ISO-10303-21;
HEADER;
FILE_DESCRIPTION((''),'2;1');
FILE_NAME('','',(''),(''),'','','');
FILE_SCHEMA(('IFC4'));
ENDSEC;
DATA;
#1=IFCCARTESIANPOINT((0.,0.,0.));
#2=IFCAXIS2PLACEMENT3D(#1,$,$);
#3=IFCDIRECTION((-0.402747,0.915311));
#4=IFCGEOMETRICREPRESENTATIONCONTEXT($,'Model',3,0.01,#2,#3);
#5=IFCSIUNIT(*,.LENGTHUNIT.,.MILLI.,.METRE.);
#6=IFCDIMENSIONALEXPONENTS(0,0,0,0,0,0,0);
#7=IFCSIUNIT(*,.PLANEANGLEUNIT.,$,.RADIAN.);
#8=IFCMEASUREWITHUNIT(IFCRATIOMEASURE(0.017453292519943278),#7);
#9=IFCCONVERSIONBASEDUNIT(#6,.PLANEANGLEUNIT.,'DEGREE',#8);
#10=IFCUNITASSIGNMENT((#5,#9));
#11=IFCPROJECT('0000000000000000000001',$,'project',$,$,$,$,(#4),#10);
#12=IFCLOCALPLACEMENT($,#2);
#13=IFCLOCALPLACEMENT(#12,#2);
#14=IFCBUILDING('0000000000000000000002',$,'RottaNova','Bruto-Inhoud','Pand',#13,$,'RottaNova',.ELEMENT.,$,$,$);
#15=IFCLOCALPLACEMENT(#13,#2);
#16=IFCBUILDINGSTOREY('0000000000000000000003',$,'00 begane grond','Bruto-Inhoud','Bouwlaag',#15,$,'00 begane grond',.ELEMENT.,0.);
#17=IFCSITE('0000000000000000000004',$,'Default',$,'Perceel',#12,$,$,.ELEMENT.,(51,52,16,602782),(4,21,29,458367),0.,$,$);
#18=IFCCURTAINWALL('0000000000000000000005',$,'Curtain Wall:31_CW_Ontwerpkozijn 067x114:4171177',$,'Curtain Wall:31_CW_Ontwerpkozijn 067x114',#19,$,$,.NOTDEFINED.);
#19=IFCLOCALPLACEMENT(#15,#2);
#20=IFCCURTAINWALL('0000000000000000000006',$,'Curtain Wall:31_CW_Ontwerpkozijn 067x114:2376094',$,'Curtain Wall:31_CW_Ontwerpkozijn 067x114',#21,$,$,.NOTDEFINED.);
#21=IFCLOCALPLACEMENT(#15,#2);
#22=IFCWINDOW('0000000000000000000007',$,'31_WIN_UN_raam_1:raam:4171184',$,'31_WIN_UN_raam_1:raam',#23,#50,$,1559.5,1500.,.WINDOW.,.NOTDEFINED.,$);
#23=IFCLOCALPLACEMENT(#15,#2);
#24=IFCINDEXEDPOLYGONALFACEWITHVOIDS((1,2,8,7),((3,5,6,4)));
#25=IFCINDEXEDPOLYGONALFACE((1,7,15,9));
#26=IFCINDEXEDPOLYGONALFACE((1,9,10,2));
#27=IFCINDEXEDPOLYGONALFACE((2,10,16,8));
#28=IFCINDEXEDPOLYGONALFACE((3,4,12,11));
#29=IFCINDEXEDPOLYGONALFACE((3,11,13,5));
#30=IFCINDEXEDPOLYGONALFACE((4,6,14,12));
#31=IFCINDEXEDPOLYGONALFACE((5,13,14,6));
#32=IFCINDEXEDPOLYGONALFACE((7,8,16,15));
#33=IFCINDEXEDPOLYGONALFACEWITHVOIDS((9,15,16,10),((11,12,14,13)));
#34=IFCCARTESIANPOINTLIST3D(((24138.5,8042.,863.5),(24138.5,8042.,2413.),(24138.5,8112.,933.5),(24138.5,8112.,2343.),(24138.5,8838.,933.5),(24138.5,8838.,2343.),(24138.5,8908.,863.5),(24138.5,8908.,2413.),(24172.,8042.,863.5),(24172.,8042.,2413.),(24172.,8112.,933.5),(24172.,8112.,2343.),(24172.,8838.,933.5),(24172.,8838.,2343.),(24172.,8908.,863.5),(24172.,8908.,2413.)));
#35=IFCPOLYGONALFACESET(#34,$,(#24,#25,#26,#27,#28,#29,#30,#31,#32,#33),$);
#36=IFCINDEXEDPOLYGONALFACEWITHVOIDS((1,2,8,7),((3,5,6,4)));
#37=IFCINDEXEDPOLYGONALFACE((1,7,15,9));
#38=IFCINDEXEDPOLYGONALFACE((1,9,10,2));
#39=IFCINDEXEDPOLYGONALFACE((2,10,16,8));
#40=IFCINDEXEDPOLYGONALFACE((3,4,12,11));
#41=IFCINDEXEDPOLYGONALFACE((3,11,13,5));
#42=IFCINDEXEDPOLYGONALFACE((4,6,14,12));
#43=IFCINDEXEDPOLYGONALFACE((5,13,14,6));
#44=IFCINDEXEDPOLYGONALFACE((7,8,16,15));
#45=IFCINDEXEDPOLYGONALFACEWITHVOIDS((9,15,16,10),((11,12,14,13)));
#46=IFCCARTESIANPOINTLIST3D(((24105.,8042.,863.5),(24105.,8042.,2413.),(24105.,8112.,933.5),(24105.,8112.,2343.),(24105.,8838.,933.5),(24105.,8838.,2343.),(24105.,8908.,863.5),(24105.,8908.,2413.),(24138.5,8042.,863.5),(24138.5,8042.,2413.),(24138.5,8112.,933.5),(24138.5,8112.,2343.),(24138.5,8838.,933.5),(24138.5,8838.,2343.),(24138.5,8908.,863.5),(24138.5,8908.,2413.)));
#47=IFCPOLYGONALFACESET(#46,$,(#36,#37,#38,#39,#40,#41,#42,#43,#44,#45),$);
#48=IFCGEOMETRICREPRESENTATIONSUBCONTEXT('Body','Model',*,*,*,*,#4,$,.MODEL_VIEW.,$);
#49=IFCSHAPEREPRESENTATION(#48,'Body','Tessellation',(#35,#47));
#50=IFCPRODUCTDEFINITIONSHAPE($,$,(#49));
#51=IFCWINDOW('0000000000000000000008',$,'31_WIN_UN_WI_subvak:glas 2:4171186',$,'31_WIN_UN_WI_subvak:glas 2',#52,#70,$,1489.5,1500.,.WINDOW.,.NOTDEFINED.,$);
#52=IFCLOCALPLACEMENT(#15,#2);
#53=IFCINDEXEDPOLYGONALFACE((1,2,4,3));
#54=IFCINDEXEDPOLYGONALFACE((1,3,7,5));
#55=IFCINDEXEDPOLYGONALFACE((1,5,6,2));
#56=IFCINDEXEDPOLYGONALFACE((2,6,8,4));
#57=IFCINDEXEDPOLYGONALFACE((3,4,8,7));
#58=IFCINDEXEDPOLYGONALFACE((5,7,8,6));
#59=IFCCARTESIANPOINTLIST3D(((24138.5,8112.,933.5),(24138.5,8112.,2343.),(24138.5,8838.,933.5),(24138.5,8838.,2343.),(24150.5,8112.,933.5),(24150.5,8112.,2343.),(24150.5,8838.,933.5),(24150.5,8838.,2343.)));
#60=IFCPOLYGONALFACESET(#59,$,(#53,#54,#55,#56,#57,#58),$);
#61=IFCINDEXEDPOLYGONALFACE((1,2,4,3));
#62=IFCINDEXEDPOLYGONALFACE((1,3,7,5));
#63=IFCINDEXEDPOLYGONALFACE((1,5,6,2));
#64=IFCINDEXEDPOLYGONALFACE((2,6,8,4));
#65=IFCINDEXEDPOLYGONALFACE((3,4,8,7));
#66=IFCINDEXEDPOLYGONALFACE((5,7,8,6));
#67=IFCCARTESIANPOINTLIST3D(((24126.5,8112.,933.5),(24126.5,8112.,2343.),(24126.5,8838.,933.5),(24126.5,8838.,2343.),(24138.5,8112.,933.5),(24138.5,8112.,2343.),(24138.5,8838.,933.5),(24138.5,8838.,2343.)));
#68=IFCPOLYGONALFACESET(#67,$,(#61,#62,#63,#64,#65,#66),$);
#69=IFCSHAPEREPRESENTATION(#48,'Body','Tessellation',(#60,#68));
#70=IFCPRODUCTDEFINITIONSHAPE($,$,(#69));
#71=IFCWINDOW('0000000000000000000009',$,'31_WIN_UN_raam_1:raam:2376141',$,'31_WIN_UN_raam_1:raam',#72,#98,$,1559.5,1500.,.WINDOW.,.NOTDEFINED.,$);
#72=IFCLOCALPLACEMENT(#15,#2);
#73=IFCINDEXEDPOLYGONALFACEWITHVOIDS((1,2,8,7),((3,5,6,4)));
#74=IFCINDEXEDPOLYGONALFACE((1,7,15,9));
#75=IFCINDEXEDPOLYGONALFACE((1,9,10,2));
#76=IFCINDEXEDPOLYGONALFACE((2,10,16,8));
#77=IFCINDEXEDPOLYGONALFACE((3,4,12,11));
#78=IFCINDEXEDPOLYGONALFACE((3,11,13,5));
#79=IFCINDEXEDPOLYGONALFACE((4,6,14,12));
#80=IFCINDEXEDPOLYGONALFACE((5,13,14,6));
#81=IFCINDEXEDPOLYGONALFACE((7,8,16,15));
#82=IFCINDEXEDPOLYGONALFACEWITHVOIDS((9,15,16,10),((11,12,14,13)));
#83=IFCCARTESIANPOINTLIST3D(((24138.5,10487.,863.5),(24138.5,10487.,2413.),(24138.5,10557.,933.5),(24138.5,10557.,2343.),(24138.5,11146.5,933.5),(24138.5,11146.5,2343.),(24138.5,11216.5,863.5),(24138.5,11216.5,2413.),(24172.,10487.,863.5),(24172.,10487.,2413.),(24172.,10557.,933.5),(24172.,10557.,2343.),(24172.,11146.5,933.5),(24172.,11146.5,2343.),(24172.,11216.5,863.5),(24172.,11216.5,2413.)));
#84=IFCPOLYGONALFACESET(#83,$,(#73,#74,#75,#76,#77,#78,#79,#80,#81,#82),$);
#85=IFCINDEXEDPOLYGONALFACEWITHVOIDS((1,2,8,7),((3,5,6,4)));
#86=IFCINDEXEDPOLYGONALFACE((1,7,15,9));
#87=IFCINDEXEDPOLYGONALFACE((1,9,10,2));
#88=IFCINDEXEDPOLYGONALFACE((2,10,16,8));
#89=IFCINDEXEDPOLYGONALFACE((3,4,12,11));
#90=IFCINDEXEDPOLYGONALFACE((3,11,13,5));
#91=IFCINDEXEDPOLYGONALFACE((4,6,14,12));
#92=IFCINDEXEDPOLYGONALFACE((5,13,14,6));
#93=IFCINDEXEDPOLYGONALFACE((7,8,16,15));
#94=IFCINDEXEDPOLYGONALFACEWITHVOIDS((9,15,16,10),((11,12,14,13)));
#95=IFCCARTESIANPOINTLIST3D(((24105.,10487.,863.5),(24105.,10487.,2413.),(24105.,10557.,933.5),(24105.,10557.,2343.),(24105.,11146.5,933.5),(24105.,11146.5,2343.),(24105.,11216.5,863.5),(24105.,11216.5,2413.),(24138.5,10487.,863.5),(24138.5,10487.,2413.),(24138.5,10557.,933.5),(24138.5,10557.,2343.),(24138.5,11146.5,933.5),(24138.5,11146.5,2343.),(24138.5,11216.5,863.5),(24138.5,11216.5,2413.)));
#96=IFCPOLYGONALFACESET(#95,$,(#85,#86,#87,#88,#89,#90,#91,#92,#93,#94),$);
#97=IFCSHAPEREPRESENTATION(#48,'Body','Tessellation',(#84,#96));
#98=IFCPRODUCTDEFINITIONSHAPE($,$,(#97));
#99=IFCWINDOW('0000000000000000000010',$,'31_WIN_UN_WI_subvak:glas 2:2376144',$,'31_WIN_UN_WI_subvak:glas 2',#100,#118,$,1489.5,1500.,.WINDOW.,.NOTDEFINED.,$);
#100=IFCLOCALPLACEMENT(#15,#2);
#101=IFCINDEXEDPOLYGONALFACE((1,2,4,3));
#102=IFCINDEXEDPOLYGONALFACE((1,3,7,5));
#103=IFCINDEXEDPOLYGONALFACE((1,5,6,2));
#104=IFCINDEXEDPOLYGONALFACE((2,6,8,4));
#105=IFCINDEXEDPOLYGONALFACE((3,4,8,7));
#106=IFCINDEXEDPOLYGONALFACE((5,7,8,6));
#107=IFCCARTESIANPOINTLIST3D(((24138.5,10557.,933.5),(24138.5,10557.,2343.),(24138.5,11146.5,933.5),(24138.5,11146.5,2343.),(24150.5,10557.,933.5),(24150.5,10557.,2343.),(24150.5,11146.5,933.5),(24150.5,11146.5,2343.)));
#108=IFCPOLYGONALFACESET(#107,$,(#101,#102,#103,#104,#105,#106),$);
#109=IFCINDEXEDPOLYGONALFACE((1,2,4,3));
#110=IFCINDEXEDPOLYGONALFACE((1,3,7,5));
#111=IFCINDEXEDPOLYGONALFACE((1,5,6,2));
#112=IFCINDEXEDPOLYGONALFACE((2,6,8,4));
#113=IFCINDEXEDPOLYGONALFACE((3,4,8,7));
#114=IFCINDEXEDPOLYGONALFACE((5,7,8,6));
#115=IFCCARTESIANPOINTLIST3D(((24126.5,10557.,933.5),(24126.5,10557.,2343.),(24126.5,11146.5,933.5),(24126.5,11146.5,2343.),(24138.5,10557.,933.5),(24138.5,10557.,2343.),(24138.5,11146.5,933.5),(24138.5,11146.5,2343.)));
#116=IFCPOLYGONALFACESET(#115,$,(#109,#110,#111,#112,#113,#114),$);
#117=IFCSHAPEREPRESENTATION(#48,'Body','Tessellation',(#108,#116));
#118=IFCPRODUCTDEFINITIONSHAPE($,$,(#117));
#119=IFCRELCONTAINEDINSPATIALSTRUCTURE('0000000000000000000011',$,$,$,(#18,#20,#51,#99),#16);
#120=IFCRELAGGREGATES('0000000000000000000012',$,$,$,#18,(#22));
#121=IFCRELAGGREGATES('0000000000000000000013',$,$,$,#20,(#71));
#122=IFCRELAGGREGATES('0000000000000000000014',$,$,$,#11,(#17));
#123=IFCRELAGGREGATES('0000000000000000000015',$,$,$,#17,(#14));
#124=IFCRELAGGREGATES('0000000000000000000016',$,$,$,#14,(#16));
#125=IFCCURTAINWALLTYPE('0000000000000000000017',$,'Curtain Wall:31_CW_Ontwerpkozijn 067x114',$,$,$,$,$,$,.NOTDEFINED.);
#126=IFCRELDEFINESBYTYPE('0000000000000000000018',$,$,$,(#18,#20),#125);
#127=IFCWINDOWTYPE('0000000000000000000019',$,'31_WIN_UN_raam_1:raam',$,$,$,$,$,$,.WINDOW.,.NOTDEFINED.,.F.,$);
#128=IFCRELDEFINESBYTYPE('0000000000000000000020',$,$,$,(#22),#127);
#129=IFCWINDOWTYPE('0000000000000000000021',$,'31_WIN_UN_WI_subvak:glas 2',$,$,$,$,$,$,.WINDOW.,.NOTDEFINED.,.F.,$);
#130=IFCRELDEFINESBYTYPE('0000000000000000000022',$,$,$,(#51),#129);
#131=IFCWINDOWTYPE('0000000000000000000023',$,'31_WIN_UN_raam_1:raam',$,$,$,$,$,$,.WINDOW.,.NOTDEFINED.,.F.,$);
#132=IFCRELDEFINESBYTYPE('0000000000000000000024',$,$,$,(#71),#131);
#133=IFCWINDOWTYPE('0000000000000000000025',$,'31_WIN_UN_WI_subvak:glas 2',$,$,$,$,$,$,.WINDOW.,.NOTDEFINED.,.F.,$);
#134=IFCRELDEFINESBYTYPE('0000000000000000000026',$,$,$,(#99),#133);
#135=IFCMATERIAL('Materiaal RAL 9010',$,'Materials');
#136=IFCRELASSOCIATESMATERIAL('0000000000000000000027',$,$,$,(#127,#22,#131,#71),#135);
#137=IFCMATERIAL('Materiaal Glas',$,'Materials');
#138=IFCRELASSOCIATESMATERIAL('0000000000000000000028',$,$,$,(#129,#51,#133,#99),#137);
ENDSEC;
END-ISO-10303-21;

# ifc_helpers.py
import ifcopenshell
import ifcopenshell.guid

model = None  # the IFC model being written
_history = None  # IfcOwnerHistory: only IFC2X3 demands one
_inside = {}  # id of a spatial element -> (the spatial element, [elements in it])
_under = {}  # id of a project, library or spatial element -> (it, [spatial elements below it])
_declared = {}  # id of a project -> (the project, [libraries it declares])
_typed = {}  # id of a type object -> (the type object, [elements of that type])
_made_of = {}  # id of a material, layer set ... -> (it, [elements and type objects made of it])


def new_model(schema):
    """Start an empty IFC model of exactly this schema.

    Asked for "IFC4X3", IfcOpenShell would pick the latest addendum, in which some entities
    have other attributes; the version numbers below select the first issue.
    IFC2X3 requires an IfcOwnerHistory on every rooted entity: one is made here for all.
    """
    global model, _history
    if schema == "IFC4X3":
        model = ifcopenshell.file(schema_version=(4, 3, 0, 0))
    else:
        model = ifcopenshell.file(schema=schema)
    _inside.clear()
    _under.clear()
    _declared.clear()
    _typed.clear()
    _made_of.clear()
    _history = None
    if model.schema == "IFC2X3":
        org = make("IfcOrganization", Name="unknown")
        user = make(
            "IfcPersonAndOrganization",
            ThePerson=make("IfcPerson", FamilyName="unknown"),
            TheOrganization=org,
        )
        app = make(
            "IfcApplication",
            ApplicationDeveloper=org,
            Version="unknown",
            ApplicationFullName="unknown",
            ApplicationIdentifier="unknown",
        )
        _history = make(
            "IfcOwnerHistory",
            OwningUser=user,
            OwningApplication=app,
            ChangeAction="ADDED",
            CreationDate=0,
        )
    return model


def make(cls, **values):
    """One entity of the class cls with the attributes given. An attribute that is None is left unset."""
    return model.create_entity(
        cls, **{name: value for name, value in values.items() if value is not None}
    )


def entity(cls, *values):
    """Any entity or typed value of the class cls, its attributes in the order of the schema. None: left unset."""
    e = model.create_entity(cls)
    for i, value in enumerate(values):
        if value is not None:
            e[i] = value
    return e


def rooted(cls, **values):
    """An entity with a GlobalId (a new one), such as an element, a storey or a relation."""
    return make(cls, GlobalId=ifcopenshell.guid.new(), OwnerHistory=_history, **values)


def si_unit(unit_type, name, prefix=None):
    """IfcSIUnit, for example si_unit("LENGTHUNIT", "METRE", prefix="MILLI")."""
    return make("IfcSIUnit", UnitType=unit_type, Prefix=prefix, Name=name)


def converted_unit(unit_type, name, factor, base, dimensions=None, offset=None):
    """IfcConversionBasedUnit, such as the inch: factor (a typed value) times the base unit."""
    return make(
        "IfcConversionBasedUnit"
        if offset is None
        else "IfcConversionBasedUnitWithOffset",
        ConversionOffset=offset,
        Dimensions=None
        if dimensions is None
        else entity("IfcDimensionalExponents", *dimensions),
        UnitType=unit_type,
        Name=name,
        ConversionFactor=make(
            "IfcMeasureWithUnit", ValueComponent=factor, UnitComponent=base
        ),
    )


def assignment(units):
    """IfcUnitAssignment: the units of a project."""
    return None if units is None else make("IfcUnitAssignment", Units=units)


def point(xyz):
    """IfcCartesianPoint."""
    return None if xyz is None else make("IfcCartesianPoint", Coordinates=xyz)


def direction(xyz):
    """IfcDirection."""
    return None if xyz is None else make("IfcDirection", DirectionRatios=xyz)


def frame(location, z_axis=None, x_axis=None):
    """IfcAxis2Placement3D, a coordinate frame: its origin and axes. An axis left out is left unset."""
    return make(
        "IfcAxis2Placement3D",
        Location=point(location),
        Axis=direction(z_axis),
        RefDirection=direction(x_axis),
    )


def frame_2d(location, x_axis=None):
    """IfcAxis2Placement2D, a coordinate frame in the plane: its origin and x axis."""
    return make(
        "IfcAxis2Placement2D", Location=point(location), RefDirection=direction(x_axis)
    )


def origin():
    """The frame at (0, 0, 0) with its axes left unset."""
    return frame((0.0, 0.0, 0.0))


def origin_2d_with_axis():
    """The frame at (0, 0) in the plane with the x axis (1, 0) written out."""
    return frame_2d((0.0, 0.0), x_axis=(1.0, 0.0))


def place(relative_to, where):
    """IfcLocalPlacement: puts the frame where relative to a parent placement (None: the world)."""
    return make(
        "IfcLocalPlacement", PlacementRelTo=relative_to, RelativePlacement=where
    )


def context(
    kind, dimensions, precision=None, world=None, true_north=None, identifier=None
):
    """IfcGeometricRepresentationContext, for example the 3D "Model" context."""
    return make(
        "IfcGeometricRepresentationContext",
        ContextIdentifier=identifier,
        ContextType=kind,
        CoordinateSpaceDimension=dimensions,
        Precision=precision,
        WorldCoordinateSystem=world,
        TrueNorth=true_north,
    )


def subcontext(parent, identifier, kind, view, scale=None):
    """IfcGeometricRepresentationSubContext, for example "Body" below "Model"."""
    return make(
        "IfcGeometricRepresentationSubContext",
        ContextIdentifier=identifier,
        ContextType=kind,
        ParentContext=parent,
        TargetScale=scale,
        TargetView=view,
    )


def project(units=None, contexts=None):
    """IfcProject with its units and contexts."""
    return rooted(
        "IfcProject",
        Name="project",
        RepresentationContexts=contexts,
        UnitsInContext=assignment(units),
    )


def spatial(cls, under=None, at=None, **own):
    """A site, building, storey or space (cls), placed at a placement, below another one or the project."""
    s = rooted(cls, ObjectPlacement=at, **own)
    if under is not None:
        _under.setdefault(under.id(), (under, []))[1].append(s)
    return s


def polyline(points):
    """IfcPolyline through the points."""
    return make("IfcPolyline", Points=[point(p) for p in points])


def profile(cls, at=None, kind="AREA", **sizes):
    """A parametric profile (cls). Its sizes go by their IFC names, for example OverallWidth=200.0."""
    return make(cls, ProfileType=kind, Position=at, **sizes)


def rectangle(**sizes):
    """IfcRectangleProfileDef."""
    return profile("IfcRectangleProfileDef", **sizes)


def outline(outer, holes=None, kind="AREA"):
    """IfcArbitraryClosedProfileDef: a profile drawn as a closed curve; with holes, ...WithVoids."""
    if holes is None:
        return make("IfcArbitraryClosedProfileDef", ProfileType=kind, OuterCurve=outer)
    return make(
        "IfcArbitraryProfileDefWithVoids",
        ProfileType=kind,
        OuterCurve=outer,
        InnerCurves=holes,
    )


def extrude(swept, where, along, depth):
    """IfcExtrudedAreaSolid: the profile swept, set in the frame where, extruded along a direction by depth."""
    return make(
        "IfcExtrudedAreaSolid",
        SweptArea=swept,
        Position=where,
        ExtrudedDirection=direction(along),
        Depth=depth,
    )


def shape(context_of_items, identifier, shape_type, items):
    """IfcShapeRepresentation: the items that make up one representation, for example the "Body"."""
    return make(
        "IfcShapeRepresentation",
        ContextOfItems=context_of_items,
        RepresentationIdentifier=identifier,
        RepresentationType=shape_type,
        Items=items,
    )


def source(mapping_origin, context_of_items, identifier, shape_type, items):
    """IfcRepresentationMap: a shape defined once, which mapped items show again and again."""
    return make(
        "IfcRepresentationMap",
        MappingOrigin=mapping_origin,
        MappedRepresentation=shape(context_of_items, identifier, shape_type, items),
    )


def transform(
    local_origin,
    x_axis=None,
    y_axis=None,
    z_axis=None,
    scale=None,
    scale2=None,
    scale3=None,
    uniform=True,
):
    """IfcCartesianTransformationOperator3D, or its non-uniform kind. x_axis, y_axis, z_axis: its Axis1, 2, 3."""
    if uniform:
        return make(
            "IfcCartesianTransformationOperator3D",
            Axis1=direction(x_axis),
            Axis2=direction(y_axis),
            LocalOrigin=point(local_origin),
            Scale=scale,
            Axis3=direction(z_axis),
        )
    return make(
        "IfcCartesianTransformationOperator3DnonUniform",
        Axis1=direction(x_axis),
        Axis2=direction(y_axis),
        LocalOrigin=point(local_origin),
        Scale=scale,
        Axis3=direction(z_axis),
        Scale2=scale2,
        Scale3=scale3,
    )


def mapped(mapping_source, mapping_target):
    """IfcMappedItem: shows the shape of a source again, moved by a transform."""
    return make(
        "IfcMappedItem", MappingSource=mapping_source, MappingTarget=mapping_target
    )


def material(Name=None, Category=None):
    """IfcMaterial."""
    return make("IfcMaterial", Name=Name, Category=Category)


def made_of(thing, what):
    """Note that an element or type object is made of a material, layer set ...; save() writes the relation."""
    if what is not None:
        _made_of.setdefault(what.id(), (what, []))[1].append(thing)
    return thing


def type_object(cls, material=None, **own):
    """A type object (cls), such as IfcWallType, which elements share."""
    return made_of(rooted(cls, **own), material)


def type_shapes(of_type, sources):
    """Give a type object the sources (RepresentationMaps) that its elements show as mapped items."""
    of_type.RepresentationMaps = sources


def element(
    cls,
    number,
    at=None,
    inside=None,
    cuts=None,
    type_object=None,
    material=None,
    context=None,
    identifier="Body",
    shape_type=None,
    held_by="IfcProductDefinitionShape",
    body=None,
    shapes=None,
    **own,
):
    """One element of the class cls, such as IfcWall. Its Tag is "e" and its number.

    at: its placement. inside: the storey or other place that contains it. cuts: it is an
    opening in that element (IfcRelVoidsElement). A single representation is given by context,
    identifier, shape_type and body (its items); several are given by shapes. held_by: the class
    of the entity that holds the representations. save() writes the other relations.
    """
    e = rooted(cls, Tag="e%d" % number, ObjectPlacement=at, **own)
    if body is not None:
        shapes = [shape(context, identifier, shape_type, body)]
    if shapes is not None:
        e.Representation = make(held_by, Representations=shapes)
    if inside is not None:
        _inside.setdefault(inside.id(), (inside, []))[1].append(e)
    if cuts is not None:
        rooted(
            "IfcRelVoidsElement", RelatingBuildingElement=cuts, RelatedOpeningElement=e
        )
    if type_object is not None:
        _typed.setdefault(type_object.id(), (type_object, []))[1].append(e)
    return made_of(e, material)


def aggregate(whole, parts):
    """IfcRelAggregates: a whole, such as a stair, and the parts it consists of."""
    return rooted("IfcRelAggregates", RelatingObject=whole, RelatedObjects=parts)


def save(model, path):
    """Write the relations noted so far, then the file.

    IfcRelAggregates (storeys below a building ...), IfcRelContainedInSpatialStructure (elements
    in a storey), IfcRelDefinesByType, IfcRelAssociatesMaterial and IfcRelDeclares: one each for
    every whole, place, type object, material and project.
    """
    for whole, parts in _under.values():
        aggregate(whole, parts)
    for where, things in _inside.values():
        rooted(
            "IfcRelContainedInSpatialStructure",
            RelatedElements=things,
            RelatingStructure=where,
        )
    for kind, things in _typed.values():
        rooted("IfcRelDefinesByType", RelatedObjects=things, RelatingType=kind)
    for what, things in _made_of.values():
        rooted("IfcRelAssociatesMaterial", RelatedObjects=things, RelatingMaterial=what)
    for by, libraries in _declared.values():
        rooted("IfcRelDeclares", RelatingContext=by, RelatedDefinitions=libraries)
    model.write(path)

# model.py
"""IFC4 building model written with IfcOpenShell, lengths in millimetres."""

from ifc_helpers import new_model, entity, si_unit, converted_unit, direction, frame, frame_2d, origin, origin_2d_with_axis, place, context, subcontext, project, spatial, polyline, rectangle, outline, extrude, source, transform, mapped, material, type_object, type_shapes, element, aggregate, save


model = new_model("IFC4")

# Units and contexts
model_context = context("Model", 3, precision=0.01, world=origin(), true_north=direction((-0.402747, 0.915311)))
body_context = subcontext(model_context, "Body", "Model", "MODEL_VIEW")
ifc_project = project(units=[si_unit("LENGTHUNIT", "METRE", prefix="MILLI"), converted_unit("PLANEANGLEUNIT", "DEGREE", entity("IfcRatioMeasure", 0.017453292519943278), si_unit("PLANEANGLEUNIT", "RADIAN"), dimensions=[0, 0, 0, 0, 0, 0, 0])], contexts=[model_context])

# Site, building, storey
site_placement = place(None, origin())
site = spatial("IfcSite", under=ifc_project, at=site_placement, Name="Default", ObjectType="Perceel", CompositionType="ELEMENT", RefLatitude=(51, 52, 16, 602782), RefLongitude=(4, 21, 29, 458367), RefElevation=0.0)
building_placement = place(site_placement, origin())
building = spatial("IfcBuilding", under=site, at=building_placement, Name="RottaNova", Description="Bruto-Inhoud", ObjectType="Pand", LongName="RottaNova", CompositionType="ELEMENT")
storey_placement = place(building_placement, origin())
storey = spatial("IfcBuildingStorey", under=building, at=storey_placement, Name="00 begane grond", Description="Bruto-Inhoud", ObjectType="Bouwlaag", LongName="00 begane grond", CompositionType="ELEMENT", Elevation=0.0)

# Curtain wall
curtain_wall_type = type_object("IfcCurtainWallType", Name="Curtain Wall:31_CW_Ontwerpkozijn 067x114", PredefinedType="NOTDEFINED")
curtain_wall_1_placement = place(storey_placement, origin())
curtain_wall_1 = element("IfcCurtainWall", 1, at=curtain_wall_1_placement, inside=storey, type_object=curtain_wall_type, Name="Curtain Wall:31_CW_Ontwerpkozijn 067x114:4171177", ObjectType="Curtain Wall:31_CW_Ontwerpkozijn 067x114", PredefinedType="NOTDEFINED")

# Curtain wall
curtain_wall_2_placement = place(storey_placement, origin())
curtain_wall_2 = element("IfcCurtainWall", 2, at=curtain_wall_2_placement, inside=storey, type_object=curtain_wall_type, Name="Curtain Wall:31_CW_Ontwerpkozijn 067x114:2376094", ObjectType="Curtain Wall:31_CW_Ontwerpkozijn 067x114", PredefinedType="NOTDEFINED")

# Shared definitions
ifc_material_1 = material(Name="Materiaal Glas", Category="Materials")

# Windows
ifc_material_2 = material(Name="Materiaal RAL 9010", Category="Materials")
window_type_1 = type_object("IfcWindowType", Name="31_WIN_UN_raam_1:raam", ParameterTakesPrecedence=False, PartitioningType="NOTDEFINED", PredefinedType="WINDOW", material=ifc_material_2)
shared_shape_1 = source(origin(), body_context, "Body", "SweptSolid", [
    extrude(outline(polyline([(-433.0, -774.7), (433.0, -774.7), (433.0, 774.7), (-433.0, 774.7), (-433.0, -774.7)]), holes=[polyline([(-363.0, 704.7), (363.0, 704.7), (363.0, -704.8), (-363.0, -704.8), (-363.0, 704.7)])]), frame((0.0, 58.5, 774.8), z_axis=(0.0, 1.0, 0.0), x_axis=(1.0, 0.0, 0.0)), (0.0, 0.0, 1.0), 33.5),
    extrude(outline(polyline([(-433.0, -774.7), (433.0, -774.7), (433.0, 774.7), (-433.0, 774.7), (-433.0, -774.7)]), holes=[polyline([(-363.0, 704.7), (363.0, 704.7), (363.0, -704.8), (-363.0, -704.8), (-363.0, 704.7)])]), frame((0.0, 25.0, 774.8), z_axis=(0.0, 1.0, 0.0), x_axis=(1.0, 0.0, 0.0)), (0.0, 0.0, 1.0), 33.5),
])
type_shapes(window_type_1, [shared_shape_1])
window_1_placement = place(curtain_wall_1_placement, frame((24080.0, 8475.0, 863.5), z_axis=(0.0, 0.0, 1.0), x_axis=(0.0, -1.0, 0.0)))
window_1 = element("IfcWindow", 3, at=window_1_placement, type_object=window_type_1, material=ifc_material_2, Name="31_WIN_UN_raam_1:raam:4171184", ObjectType="31_WIN_UN_raam_1:raam", OverallHeight=1559.5, OverallWidth=1500.0, PartitioningType="NOTDEFINED", PredefinedType="WINDOW", context=body_context, shape_type="MappedRepresentation", body=[
    mapped(shared_shape_1, transform((0.0, 0.0, 0.0), scale=1.0)),
])
aggregate(curtain_wall_1, [window_1])
window_type_2 = type_object("IfcWindowType", Name="31_WIN_UN_WI_subvak:glas 2", ParameterTakesPrecedence=False, PartitioningType="NOTDEFINED", PredefinedType="WINDOW", material=ifc_material_1)
shared_shape_2 = source(origin(), body_context, "Body", "SweptSolid", [
    extrude(rectangle(XDim=12.0, YDim=726.0, at=frame_2d((0.0, 0.0), x_axis=(1.0, 0.0))), frame((0.0, 6.0, 0.0), z_axis=(0.0, 0.0, 1.0), x_axis=(0.0, -1.0, 0.0)), (0.0, 0.0, 1.0), 1409.5),
    extrude(rectangle(XDim=12.0, YDim=726.0, at=frame_2d((0.0, 0.0), x_axis=(1.0, 0.0))), frame((0.0, -6.0, 0.0), z_axis=(0.0, 0.0, 1.0), x_axis=(0.0, -1.0, 0.0)), (0.0, 0.0, 1.0), 1409.5),
])
type_shapes(window_type_2, [shared_shape_2])
window_2_placement = place(storey_placement, frame((24138.5, 8475.0, 933.5), z_axis=(0.0, 0.0, 1.0), x_axis=(0.0, -1.0, 0.0)))
element("IfcWindow", 4, at=window_2_placement, inside=storey, type_object=window_type_2, material=ifc_material_1, Name="31_WIN_UN_WI_subvak:glas 2:4171186", ObjectType="31_WIN_UN_WI_subvak:glas 2", OverallHeight=1489.5, OverallWidth=1500.0, PartitioningType="NOTDEFINED", PredefinedType="WINDOW", context=body_context, shape_type="MappedRepresentation", body=[
    mapped(shared_shape_2, transform((0.0, 0.0, 0.0), scale=1.0)),
])
window_type_3 = type_object("IfcWindowType", Name="31_WIN_UN_raam_1:raam", ParameterTakesPrecedence=False, PartitioningType="NOTDEFINED", PredefinedType="WINDOW", material=ifc_material_2)
shared_shape_3 = source(origin(), body_context, "Body", "SweptSolid", [
    extrude(outline(polyline([(-364.7, -774.7), (364.7, -774.7), (364.7, 774.7), (-364.7, 774.7), (-364.7, -774.7)]), holes=[polyline([(-294.7, 704.7), (294.7, 704.7), (294.7, -704.8), (-294.7, -704.8), (-294.7, 704.7)])]), frame((0.0, 92.0, 774.8), z_axis=(0.0, -1.0, 0.0), x_axis=(-1.0, 0.0, 0.0)), (0.0, 0.0, 1.0), 33.5),
    extrude(outline(polyline([(-364.7, -774.7), (364.7, -774.7), (364.7, 774.7), (-364.7, 774.7), (-364.7, -774.7)]), holes=[polyline([(-294.7, 704.7), (294.7, 704.7), (294.7, -704.8), (-294.7, -704.8), (-294.7, 704.7)])]), frame((0.0, 58.5, 774.8), z_axis=(0.0, -1.0, 0.0), x_axis=(-1.0, 0.0, 0.0)), (0.0, 0.0, 1.0), 33.5),
])
type_shapes(window_type_3, [shared_shape_3])
window_3_placement = place(curtain_wall_2_placement, frame((24080.0, 10851.7, 863.5), z_axis=(0.0, 0.0, 1.0), x_axis=(0.0, -1.0, 0.0)))
window_3 = element("IfcWindow", 5, at=window_3_placement, type_object=window_type_3, material=ifc_material_2, Name="31_WIN_UN_raam_1:raam:2376141", ObjectType="31_WIN_UN_raam_1:raam", OverallHeight=1559.5, OverallWidth=1500.0, PartitioningType="NOTDEFINED", PredefinedType="WINDOW", context=body_context, shape_type="MappedRepresentation", body=[
    mapped(shared_shape_3, transform((0.0, 0.0, 0.0), scale=1.0)),
])
aggregate(curtain_wall_2, [window_3])
window_type_4 = type_object("IfcWindowType", Name="31_WIN_UN_WI_subvak:glas 2", ParameterTakesPrecedence=False, PartitioningType="NOTDEFINED", PredefinedType="WINDOW", material=ifc_material_1)
shared_shape_4 = source(origin(), body_context, "Body", "SweptSolid", [
    extrude(rectangle(XDim=589.5, YDim=12.0, at=origin_2d_with_axis()), frame((0.0, -6.0, 0.0)), (0.0, 0.0, 1.0), 1409.5),
    extrude(rectangle(XDim=589.5, YDim=12.0, at=origin_2d_with_axis()), frame((0.0, 6.0, 0.0)), (0.0, 0.0, 1.0), 1409.5),
])
type_shapes(window_type_4, [shared_shape_4])
window_4_placement = place(storey_placement, frame((24138.5, 10851.7, 933.5), z_axis=(0.0, 0.0, 1.0), x_axis=(0.0, 1.0, 0.0)))
element("IfcWindow", 6, at=window_4_placement, inside=storey, type_object=window_type_4, material=ifc_material_1, Name="31_WIN_UN_WI_subvak:glas 2:2376144", ObjectType="31_WIN_UN_WI_subvak:glas 2", OverallHeight=1489.5, OverallWidth=1500.0, PartitioningType="NOTDEFINED", PredefinedType="WINDOW", context=body_context, shape_type="MappedRepresentation", body=[
    mapped(shared_shape_4, transform((0.0, 0.0, 0.0), scale=1.0)),
])

save(model, "model.ifc")
